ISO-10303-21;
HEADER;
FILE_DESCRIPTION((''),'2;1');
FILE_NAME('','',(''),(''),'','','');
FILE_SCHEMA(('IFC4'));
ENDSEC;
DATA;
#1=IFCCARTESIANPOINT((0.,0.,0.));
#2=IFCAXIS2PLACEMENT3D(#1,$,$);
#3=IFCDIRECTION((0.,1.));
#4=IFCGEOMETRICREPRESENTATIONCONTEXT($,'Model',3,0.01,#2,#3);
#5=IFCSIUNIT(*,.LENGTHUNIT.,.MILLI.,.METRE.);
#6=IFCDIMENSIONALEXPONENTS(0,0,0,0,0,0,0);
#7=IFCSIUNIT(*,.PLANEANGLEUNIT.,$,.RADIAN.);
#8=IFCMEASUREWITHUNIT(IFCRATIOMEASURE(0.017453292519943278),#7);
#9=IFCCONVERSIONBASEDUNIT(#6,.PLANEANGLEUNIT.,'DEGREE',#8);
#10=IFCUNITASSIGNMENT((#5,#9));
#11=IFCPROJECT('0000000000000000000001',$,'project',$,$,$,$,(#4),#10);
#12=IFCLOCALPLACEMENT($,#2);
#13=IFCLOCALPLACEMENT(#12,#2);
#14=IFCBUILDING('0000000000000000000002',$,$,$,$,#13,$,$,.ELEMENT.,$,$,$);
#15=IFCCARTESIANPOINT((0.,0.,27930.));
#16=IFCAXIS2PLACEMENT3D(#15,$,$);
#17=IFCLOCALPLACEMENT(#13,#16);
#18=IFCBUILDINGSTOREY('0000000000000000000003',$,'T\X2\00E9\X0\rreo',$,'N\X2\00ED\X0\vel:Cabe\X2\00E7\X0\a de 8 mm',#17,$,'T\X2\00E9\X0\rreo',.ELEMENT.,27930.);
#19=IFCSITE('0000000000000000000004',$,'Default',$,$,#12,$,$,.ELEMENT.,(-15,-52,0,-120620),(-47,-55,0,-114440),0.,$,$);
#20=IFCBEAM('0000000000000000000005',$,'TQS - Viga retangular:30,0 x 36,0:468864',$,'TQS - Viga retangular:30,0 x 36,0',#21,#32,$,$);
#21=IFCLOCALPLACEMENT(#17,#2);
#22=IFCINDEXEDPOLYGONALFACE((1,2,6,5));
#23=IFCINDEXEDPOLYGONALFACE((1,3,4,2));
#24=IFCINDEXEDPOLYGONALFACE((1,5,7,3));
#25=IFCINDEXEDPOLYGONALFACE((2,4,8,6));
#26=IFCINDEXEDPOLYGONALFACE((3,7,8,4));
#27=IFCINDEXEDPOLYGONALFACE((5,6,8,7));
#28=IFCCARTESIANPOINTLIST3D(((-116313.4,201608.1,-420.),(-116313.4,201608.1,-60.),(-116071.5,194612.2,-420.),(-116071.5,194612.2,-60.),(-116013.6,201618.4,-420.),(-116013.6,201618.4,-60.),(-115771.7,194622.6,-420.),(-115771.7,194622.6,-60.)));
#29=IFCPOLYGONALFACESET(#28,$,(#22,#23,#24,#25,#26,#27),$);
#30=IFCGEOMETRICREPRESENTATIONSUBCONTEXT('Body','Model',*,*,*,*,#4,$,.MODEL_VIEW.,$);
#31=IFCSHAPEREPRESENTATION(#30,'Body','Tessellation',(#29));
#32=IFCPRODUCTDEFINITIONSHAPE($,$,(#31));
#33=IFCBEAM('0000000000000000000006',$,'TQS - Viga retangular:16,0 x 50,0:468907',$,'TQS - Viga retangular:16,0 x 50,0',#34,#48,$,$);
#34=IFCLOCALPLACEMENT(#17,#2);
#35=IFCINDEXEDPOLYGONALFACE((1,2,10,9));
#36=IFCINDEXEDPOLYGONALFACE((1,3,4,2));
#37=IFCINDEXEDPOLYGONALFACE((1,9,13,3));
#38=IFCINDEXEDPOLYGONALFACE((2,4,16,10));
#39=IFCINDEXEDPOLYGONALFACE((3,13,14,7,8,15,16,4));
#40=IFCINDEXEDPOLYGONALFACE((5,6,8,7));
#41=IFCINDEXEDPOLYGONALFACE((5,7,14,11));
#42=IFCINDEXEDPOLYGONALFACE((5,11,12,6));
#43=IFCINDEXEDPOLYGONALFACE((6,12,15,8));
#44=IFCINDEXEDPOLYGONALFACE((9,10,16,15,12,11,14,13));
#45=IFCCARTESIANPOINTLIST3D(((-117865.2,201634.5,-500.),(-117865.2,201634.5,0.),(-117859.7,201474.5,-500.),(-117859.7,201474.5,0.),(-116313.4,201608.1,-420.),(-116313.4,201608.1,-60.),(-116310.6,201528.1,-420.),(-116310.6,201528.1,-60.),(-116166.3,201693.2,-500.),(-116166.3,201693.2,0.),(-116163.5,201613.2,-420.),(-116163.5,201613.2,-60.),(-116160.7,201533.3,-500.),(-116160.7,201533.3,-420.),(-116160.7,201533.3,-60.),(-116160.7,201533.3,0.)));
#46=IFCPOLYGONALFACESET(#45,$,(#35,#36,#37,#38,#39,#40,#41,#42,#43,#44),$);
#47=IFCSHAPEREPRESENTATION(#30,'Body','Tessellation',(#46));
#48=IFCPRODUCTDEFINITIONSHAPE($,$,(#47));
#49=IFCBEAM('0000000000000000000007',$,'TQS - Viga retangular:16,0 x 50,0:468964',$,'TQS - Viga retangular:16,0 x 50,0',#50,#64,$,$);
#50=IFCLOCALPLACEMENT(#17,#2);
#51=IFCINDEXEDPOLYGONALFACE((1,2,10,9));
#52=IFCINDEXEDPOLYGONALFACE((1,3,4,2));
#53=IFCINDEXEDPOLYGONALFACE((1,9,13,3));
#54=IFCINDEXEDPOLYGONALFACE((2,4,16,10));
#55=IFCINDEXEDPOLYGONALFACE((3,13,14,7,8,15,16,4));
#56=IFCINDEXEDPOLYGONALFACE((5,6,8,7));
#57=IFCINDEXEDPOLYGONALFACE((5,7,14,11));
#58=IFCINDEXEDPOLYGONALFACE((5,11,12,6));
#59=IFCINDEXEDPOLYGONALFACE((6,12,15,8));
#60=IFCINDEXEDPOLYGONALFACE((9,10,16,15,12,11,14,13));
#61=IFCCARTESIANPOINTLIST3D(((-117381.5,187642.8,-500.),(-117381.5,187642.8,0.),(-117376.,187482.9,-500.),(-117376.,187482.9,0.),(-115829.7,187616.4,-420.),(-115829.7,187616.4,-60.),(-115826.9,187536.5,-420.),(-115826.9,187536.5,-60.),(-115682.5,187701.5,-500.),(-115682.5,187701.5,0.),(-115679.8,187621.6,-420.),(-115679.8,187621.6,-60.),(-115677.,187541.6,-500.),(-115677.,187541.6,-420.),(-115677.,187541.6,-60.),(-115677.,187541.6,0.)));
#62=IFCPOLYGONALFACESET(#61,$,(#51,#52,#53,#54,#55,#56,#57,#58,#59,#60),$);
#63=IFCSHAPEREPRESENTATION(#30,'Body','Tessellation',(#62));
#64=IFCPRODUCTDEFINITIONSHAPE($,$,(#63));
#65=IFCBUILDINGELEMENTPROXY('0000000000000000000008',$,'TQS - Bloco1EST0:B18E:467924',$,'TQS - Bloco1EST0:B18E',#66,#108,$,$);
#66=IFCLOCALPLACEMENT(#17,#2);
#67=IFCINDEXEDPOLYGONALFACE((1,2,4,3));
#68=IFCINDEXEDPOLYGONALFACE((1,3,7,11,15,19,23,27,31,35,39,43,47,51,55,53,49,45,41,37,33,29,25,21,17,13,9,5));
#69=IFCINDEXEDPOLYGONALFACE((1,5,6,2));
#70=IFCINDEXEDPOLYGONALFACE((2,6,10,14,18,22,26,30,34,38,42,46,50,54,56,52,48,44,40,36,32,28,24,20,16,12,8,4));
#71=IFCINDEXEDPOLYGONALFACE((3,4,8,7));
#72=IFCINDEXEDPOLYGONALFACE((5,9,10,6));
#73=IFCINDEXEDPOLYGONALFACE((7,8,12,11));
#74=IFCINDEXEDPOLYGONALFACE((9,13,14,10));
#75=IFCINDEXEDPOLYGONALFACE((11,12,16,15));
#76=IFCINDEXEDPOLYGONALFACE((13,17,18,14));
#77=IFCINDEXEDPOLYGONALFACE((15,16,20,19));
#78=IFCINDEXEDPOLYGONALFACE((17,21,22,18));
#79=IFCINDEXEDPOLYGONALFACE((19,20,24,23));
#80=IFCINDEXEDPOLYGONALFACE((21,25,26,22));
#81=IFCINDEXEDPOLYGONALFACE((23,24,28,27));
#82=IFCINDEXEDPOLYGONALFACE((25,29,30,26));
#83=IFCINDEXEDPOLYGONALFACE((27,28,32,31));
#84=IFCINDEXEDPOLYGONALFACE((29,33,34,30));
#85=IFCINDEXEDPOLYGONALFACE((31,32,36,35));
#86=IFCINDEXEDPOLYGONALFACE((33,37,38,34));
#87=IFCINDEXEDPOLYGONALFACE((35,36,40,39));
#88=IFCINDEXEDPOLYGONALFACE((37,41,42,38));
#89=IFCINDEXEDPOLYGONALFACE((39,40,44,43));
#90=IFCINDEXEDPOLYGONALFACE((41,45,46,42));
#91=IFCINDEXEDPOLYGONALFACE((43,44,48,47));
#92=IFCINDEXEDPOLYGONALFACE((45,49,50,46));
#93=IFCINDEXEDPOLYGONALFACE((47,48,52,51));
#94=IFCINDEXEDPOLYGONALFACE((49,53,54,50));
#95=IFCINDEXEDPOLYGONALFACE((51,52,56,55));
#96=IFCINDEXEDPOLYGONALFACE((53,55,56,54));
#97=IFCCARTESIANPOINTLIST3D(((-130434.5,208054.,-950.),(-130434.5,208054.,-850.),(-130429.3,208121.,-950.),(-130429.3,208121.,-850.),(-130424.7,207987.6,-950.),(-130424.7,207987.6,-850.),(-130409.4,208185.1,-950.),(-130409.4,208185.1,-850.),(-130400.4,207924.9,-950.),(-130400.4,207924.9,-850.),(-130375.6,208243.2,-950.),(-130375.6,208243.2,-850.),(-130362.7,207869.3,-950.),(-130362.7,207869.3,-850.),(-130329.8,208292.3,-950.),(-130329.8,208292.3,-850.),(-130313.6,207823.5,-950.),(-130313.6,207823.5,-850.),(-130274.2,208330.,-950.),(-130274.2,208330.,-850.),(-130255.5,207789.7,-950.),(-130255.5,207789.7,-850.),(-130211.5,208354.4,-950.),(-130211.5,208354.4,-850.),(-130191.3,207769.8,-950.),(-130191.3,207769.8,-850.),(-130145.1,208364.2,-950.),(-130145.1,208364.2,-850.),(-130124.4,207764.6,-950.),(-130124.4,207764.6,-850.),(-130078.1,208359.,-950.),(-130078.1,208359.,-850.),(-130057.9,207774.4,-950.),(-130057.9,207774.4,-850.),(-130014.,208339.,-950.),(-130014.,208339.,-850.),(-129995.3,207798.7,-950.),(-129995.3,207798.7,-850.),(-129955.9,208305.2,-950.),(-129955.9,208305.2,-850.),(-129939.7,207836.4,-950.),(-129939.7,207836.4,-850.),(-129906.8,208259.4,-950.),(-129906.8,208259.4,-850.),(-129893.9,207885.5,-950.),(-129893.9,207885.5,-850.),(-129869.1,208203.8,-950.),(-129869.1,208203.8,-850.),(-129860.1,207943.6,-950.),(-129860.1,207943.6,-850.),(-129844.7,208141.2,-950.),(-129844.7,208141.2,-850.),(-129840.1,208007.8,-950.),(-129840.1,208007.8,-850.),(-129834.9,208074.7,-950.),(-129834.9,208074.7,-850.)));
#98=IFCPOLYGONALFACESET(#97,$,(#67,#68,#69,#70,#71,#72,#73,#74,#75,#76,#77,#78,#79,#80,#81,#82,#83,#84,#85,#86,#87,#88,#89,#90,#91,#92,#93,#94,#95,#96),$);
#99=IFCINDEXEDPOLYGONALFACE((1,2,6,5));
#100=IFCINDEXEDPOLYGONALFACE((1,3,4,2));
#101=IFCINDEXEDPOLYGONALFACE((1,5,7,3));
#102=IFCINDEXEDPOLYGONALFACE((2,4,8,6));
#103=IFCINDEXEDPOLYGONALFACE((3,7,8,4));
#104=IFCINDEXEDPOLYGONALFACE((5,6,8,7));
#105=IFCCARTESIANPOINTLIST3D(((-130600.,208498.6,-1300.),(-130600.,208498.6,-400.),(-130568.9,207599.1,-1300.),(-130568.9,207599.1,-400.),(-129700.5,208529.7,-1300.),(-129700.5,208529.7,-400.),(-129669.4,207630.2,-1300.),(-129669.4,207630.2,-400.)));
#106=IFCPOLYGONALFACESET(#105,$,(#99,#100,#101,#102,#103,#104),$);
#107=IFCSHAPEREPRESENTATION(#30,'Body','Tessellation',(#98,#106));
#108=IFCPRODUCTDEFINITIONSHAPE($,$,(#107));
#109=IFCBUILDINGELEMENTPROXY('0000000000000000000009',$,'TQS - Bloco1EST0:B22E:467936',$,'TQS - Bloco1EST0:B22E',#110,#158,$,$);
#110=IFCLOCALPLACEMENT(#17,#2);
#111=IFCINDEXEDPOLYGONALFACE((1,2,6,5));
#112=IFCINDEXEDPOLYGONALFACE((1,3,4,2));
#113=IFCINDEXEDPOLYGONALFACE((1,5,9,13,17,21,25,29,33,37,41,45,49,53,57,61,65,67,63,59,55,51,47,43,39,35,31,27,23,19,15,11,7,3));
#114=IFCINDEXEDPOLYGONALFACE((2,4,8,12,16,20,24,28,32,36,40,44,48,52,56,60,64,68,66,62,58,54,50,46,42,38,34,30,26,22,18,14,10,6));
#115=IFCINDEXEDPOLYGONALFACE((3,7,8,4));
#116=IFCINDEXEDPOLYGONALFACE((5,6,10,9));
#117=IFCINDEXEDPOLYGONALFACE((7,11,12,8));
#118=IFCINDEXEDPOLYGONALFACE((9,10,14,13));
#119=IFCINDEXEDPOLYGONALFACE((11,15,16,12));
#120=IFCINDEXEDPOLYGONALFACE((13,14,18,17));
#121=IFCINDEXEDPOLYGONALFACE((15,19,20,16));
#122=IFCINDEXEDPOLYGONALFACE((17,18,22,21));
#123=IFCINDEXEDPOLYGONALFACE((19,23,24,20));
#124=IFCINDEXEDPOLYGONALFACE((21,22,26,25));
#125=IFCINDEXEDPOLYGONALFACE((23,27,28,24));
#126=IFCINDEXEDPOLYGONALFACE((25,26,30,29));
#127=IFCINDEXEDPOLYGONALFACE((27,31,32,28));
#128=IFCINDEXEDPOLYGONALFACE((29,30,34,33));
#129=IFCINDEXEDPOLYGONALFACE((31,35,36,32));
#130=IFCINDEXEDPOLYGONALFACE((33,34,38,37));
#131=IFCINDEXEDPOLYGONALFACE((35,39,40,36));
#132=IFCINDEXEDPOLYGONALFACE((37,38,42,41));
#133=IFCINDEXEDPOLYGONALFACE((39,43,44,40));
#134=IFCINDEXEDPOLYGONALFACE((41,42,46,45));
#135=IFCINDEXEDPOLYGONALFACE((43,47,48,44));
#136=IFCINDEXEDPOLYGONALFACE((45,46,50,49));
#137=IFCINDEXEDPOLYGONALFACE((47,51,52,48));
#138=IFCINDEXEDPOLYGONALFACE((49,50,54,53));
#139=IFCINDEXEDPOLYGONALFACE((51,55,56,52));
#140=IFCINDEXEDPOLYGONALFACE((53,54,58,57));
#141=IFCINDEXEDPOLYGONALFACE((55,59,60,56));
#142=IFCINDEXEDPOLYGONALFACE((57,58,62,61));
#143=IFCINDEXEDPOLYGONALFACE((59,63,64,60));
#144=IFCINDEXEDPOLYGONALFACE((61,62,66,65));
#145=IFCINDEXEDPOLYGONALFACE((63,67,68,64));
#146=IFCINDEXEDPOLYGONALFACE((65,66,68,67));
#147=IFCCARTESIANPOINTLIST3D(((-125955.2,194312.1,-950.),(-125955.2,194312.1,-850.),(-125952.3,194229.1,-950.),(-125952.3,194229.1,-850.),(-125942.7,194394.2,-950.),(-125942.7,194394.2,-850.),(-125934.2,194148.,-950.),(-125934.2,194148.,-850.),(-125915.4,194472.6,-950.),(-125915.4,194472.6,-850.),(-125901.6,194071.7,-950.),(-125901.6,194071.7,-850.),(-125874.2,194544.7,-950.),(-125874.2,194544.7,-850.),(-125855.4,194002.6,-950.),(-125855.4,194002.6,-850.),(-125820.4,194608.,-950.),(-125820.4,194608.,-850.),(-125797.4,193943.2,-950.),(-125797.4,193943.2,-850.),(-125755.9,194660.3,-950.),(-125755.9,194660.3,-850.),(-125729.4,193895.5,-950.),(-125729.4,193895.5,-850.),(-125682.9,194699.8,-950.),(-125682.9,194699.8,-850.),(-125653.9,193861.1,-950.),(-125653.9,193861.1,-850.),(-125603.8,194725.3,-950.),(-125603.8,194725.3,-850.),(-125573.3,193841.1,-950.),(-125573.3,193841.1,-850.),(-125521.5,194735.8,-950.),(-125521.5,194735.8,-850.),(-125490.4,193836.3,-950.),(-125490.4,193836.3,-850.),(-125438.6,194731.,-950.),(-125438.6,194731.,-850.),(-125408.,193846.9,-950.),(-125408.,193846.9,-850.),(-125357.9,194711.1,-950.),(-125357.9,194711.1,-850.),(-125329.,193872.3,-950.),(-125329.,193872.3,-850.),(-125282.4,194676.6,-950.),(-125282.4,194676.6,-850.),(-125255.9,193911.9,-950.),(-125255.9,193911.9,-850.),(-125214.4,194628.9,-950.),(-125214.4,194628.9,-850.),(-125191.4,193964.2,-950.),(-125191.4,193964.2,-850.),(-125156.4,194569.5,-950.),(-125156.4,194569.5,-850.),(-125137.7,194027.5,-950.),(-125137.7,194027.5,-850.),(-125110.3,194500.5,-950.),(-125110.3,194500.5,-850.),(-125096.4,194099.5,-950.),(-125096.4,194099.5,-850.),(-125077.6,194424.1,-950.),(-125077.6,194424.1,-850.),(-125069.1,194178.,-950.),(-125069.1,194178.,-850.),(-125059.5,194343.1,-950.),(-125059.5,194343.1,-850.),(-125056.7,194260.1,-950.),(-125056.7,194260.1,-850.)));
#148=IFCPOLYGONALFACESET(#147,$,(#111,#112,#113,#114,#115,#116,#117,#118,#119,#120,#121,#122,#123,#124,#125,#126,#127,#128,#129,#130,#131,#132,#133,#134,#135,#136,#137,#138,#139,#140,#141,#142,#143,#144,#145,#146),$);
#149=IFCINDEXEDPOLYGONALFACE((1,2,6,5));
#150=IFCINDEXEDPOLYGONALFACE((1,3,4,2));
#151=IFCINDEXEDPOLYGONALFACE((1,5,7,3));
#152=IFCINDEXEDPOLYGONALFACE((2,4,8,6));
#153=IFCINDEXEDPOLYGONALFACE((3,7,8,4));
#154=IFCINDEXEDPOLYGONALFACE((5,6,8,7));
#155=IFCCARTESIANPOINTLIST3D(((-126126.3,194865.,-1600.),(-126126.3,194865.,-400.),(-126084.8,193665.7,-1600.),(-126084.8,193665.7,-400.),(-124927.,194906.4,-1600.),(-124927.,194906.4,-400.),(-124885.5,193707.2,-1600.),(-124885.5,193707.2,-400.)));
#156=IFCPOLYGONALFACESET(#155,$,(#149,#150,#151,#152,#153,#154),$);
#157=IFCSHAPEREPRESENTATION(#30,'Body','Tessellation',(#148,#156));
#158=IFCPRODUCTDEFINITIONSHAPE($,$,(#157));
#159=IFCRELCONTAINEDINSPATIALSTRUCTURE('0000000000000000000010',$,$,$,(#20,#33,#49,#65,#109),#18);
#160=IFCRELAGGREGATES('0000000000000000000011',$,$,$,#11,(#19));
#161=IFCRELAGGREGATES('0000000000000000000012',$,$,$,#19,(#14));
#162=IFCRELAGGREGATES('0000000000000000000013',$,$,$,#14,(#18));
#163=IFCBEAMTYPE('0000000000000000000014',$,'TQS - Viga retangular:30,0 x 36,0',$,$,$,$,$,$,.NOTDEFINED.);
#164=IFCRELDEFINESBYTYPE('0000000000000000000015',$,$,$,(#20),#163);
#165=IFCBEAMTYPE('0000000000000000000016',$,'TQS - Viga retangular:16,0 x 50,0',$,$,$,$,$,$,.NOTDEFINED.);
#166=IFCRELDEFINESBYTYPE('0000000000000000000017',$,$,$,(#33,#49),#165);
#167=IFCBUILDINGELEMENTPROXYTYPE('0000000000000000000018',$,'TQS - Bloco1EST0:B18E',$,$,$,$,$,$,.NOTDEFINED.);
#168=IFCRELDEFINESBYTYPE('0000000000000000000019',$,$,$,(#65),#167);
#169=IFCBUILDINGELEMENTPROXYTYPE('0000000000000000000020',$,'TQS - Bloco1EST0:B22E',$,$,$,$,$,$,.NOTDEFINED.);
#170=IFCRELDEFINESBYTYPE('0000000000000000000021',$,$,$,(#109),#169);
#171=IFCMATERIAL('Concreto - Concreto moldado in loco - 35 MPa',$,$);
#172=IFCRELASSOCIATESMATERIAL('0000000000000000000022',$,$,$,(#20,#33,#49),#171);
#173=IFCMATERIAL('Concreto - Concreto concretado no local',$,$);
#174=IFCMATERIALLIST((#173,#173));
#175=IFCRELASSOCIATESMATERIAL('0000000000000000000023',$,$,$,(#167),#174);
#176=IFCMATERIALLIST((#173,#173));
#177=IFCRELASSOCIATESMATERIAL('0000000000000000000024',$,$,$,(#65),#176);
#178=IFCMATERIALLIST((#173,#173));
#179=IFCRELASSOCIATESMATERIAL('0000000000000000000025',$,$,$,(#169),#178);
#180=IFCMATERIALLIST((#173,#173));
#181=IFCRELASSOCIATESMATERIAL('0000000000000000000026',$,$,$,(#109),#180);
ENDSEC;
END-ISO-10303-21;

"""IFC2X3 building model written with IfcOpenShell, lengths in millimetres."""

from ifc_helpers import new_model, entity, si_unit, converted_unit, direction, frame, frame_2d, origin, origin_2d_with_axis, place, context, subcontext, project, spatial, polyline, rectangle, circle, extrude, boolean, clip, bounded_halfspace, source, transform, mapped, material, material_list, type_object, type_shapes, element, save


model = new_model("IFC2X3")

# Units and contexts
model_context = context("Model", 3, precision=0.01, world=origin(), true_north=direction((0.0, 1.0)))
body_context = subcontext(model_context, "Body", "Model", "MODEL_VIEW")
ifc_project = project(units=[si_unit("LENGTHUNIT", "METRE", prefix="MILLI"), converted_unit("PLANEANGLEUNIT", "DEGREE", entity("IfcRatioMeasure", 0.017453292519943278), si_unit("PLANEANGLEUNIT", "RADIAN"), dimensions=[0, 0, 0, 0, 0, 0, 0])], contexts=[model_context])

# Site, building, storey
site_placement = place(None, origin())
site = spatial("IfcSite", under=ifc_project, at=site_placement, Name="Default", CompositionType="ELEMENT", RefLatitude=(-15, -52, 0, -120620), RefLongitude=(-47, -55, 0, -114440), RefElevation=0.0)
building_placement = place(site_placement, origin())
building = spatial("IfcBuilding", under=site, at=building_placement, CompositionType="ELEMENT")
storey_placement = place(building_placement, frame((0.0, 0.0, 27930.0)))
storey = spatial("IfcBuildingStorey", under=building, at=storey_placement, Name="Térreo", ObjectType="Nível:Cabeça de 8 mm", LongName="Térreo", CompositionType="ELEMENT", Elevation=27930.0)

# Beams
ifc_material_1 = material(Name="Concreto - Concreto moldado in loco - 35 MPa")
beam_type_1 = type_object("IfcBeamType", Name="TQS - Viga retangular:30,0 x 36,0", PredefinedType="NOTDEFINED")
beam_1_placement = place(storey_placement, frame((-115921.6, 194617.4, -60.0), z_axis=(0.0, 0.0, 1.0), x_axis=(-0.034551, 0.999403, 0.0)))
element("IfcBeam", 1, at=beam_1_placement, inside=storey, type_object=beam_type_1, material=ifc_material_1, Name="TQS - Viga retangular:30,0 x 36,0:468864", ObjectType="TQS - Viga retangular:30,0 x 36,0", context=body_context, shape_type="SweptSolid", body=[
    extrude(rectangle(XDim=360.0, YDim=300.0, at=frame_2d((0.0, 0.0), x_axis=(1.0, 0.0))), frame((0.0, 0.0, -180.0), z_axis=(1.0, 0.0, 0.0), x_axis=(0.0, 0.0, -1.0)), (0.0, 0.0, 1.0), 7000.0),
])
beam_type_2 = type_object("IfcBeamType", Name="TQS - Viga retangular:16,0 x 50,0", PredefinedType="NOTDEFINED")
beam_2_placement = place(storey_placement, frame((-116163.5, 201613.2, 0.0), z_axis=(0.0, 0.0, 1.0), x_axis=(-0.999403, -0.034551, 0.0)))
element("IfcBeam", 2, at=beam_2_placement, inside=storey, type_object=beam_type_2, material=ifc_material_1, Name="TQS - Viga retangular:16,0 x 50,0:468907", ObjectType="TQS - Viga retangular:16,0 x 50,0", context=body_context, shape_type="SweptSolid", body=[
    boolean("DIFFERENCE", clip(extrude(rectangle(XDim=500.0, YDim=160.0, at=origin_2d_with_axis()), frame((0.0, 0.0, -250.0), z_axis=(1.0, 0.0, 0.0), x_axis=(0.0, 0.0, -1.0)), (0.0, 0.0, 1.0), 1700.0), bounded_halfspace(frame((150.0, 0.0, -420.0), z_axis=(-1.0, 0.0, 0.0), x_axis=(0.0, 1.0, 0.0)), False, frame((0.0, 0.0, -250.0), z_axis=(1.0, 0.0, 0.0), x_axis=(0.0, 0.0, -1.0)), polyline([(170.0, 0.0), (-190.0, 0.0), (-190.0, 80.0), (-90.0, 80.0), (170.0, 80.0), (170.0, 0.0)]))), extrude(rectangle(XDim=360.0, YDim=80.0, at=frame_2d((0.0, 0.0), x_axis=(0.0, 1.0))), frame((0.0, 40.0, -240.0), z_axis=(-1.0, 0.0, 0.0), x_axis=(0.0, -1.0, 0.0)), (0.0, 0.0, -1.0), 150.0)),
])
beam_3_placement = place(storey_placement, frame((-115679.8, 187621.6, 0.0), z_axis=(0.0, 0.0, 1.0), x_axis=(-0.999403, -0.034551, 0.0)))
element("IfcBeam", 3, at=beam_3_placement, inside=storey, type_object=beam_type_2, material=ifc_material_1, Name="TQS - Viga retangular:16,0 x 50,0:468964", ObjectType="TQS - Viga retangular:16,0 x 50,0", context=body_context, shape_type="SweptSolid", body=[
    boolean("DIFFERENCE", clip(extrude(rectangle(XDim=500.0, YDim=160.0, at=origin_2d_with_axis()), frame((0.0, 0.0, -250.0), z_axis=(1.0, 0.0, 0.0), x_axis=(0.0, 0.0, -1.0)), (0.0, 0.0, 1.0), 1700.0), bounded_halfspace(frame((150.0, 0.0, -420.0), z_axis=(-1.0, 0.0, 0.0), x_axis=(0.0, 1.0, 0.0)), False, frame((0.0, 0.0, -250.0), z_axis=(1.0, 0.0, 0.0), x_axis=(0.0, 0.0, -1.0)), polyline([(170.0, 0.0), (-190.0, 0.0), (-190.0, 80.0), (-90.0, 80.0), (170.0, 80.0), (170.0, 0.0)]))), extrude(rectangle(XDim=360.0, YDim=80.0, at=frame_2d((0.0, 0.0), x_axis=(0.0, 1.0))), frame((0.0, 40.0, -240.0), z_axis=(-1.0, 0.0, 0.0), x_axis=(0.0, -1.0, 0.0)), (0.0, 0.0, -1.0), 150.0)),
])

# Building element proxies
ifc_material_2 = material(Name="Concreto - Concreto concretado no local")
ifc_material_list_1 = material_list([ifc_material_2, ifc_material_2])
ifc_material_list_2 = material_list([ifc_material_2, ifc_material_2])
building_element_proxy_type_1 = type_object("IfcBuildingElementProxyType", Name="TQS - Bloco1EST0:B18E", PredefinedType="NOTDEFINED", material=ifc_material_list_2)
shared_shape_1 = source(origin(), body_context, "Body", "SweptSolid", [
    extrude(circle(Radius=300.0, at=frame_2d((0.0, 0.0), x_axis=(1.0, 0.0))), frame((0.0, 0.0, -550.0)), (0.0, 0.0, 1.0), 100.0),
    extrude(rectangle(XDim=900.0, YDim=900.0, at=origin_2d_with_axis()), frame((0.0, 0.0, -900.0), z_axis=(0.0, 0.0, 1.0), x_axis=(-1.0, 0.0, 0.0)), (0.0, 0.0, 1.0), 900.0),
])
type_shapes(building_element_proxy_type_1, [shared_shape_1])
proxy_1_placement = place(storey_placement, frame((-130134.7, 208064.4, -400.0), z_axis=(0.0, 0.0, 1.0), x_axis=(-0.034551, 0.999403, 0.0)))
element("IfcBuildingElementProxy", 4, at=proxy_1_placement, inside=storey, type_object=building_element_proxy_type_1, material=ifc_material_list_1, Name="TQS - Bloco1EST0:B18E:467924", ObjectType="TQS - Bloco1EST0:B18E", context=body_context, shape_type="MappedRepresentation", body=[
    mapped(shared_shape_1, transform((0.0, 0.0, 0.0), scale=1.0)),
])
ifc_material_list_3 = material_list([ifc_material_2, ifc_material_2])
ifc_material_list_4 = material_list([ifc_material_2, ifc_material_2])
building_element_proxy_type_2 = type_object("IfcBuildingElementProxyType", Name="TQS - Bloco1EST0:B22E", PredefinedType="NOTDEFINED", material=ifc_material_list_4)
shared_shape_2 = source(origin(), body_context, "Body", "SweptSolid", [
    extrude(circle(Radius=450.0, at=frame_2d((0.0, 0.0), x_axis=(1.0, 0.0))), frame((0.0, 0.0, -550.0)), (0.0, 0.0, 1.0), 100.0),
    extrude(rectangle(XDim=1200.0, YDim=1200.0, at=origin_2d_with_axis()), frame((0.0, 0.0, -1200.0), z_axis=(0.0, 0.0, 1.0), x_axis=(-1.0, 0.0, 0.0)), (0.0, 0.0, 1.0), 1200.0),
])
type_shapes(building_element_proxy_type_2, [shared_shape_2])
proxy_2_placement = place(storey_placement, frame((-125505.9, 194286.1, -400.0), z_axis=(0.0, 0.0, 1.0), x_axis=(-0.034551, 0.999403, 0.0)))
element("IfcBuildingElementProxy", 5, at=proxy_2_placement, inside=storey, type_object=building_element_proxy_type_2, material=ifc_material_list_3, Name="TQS - Bloco1EST0:B22E:467936", ObjectType="TQS - Bloco1EST0:B22E", context=body_context, shape_type="MappedRepresentation", body=[
    mapped(shared_shape_2, transform((0.0, 0.0, 0.0), scale=1.0)),
])

save(model, "model.ifc")
